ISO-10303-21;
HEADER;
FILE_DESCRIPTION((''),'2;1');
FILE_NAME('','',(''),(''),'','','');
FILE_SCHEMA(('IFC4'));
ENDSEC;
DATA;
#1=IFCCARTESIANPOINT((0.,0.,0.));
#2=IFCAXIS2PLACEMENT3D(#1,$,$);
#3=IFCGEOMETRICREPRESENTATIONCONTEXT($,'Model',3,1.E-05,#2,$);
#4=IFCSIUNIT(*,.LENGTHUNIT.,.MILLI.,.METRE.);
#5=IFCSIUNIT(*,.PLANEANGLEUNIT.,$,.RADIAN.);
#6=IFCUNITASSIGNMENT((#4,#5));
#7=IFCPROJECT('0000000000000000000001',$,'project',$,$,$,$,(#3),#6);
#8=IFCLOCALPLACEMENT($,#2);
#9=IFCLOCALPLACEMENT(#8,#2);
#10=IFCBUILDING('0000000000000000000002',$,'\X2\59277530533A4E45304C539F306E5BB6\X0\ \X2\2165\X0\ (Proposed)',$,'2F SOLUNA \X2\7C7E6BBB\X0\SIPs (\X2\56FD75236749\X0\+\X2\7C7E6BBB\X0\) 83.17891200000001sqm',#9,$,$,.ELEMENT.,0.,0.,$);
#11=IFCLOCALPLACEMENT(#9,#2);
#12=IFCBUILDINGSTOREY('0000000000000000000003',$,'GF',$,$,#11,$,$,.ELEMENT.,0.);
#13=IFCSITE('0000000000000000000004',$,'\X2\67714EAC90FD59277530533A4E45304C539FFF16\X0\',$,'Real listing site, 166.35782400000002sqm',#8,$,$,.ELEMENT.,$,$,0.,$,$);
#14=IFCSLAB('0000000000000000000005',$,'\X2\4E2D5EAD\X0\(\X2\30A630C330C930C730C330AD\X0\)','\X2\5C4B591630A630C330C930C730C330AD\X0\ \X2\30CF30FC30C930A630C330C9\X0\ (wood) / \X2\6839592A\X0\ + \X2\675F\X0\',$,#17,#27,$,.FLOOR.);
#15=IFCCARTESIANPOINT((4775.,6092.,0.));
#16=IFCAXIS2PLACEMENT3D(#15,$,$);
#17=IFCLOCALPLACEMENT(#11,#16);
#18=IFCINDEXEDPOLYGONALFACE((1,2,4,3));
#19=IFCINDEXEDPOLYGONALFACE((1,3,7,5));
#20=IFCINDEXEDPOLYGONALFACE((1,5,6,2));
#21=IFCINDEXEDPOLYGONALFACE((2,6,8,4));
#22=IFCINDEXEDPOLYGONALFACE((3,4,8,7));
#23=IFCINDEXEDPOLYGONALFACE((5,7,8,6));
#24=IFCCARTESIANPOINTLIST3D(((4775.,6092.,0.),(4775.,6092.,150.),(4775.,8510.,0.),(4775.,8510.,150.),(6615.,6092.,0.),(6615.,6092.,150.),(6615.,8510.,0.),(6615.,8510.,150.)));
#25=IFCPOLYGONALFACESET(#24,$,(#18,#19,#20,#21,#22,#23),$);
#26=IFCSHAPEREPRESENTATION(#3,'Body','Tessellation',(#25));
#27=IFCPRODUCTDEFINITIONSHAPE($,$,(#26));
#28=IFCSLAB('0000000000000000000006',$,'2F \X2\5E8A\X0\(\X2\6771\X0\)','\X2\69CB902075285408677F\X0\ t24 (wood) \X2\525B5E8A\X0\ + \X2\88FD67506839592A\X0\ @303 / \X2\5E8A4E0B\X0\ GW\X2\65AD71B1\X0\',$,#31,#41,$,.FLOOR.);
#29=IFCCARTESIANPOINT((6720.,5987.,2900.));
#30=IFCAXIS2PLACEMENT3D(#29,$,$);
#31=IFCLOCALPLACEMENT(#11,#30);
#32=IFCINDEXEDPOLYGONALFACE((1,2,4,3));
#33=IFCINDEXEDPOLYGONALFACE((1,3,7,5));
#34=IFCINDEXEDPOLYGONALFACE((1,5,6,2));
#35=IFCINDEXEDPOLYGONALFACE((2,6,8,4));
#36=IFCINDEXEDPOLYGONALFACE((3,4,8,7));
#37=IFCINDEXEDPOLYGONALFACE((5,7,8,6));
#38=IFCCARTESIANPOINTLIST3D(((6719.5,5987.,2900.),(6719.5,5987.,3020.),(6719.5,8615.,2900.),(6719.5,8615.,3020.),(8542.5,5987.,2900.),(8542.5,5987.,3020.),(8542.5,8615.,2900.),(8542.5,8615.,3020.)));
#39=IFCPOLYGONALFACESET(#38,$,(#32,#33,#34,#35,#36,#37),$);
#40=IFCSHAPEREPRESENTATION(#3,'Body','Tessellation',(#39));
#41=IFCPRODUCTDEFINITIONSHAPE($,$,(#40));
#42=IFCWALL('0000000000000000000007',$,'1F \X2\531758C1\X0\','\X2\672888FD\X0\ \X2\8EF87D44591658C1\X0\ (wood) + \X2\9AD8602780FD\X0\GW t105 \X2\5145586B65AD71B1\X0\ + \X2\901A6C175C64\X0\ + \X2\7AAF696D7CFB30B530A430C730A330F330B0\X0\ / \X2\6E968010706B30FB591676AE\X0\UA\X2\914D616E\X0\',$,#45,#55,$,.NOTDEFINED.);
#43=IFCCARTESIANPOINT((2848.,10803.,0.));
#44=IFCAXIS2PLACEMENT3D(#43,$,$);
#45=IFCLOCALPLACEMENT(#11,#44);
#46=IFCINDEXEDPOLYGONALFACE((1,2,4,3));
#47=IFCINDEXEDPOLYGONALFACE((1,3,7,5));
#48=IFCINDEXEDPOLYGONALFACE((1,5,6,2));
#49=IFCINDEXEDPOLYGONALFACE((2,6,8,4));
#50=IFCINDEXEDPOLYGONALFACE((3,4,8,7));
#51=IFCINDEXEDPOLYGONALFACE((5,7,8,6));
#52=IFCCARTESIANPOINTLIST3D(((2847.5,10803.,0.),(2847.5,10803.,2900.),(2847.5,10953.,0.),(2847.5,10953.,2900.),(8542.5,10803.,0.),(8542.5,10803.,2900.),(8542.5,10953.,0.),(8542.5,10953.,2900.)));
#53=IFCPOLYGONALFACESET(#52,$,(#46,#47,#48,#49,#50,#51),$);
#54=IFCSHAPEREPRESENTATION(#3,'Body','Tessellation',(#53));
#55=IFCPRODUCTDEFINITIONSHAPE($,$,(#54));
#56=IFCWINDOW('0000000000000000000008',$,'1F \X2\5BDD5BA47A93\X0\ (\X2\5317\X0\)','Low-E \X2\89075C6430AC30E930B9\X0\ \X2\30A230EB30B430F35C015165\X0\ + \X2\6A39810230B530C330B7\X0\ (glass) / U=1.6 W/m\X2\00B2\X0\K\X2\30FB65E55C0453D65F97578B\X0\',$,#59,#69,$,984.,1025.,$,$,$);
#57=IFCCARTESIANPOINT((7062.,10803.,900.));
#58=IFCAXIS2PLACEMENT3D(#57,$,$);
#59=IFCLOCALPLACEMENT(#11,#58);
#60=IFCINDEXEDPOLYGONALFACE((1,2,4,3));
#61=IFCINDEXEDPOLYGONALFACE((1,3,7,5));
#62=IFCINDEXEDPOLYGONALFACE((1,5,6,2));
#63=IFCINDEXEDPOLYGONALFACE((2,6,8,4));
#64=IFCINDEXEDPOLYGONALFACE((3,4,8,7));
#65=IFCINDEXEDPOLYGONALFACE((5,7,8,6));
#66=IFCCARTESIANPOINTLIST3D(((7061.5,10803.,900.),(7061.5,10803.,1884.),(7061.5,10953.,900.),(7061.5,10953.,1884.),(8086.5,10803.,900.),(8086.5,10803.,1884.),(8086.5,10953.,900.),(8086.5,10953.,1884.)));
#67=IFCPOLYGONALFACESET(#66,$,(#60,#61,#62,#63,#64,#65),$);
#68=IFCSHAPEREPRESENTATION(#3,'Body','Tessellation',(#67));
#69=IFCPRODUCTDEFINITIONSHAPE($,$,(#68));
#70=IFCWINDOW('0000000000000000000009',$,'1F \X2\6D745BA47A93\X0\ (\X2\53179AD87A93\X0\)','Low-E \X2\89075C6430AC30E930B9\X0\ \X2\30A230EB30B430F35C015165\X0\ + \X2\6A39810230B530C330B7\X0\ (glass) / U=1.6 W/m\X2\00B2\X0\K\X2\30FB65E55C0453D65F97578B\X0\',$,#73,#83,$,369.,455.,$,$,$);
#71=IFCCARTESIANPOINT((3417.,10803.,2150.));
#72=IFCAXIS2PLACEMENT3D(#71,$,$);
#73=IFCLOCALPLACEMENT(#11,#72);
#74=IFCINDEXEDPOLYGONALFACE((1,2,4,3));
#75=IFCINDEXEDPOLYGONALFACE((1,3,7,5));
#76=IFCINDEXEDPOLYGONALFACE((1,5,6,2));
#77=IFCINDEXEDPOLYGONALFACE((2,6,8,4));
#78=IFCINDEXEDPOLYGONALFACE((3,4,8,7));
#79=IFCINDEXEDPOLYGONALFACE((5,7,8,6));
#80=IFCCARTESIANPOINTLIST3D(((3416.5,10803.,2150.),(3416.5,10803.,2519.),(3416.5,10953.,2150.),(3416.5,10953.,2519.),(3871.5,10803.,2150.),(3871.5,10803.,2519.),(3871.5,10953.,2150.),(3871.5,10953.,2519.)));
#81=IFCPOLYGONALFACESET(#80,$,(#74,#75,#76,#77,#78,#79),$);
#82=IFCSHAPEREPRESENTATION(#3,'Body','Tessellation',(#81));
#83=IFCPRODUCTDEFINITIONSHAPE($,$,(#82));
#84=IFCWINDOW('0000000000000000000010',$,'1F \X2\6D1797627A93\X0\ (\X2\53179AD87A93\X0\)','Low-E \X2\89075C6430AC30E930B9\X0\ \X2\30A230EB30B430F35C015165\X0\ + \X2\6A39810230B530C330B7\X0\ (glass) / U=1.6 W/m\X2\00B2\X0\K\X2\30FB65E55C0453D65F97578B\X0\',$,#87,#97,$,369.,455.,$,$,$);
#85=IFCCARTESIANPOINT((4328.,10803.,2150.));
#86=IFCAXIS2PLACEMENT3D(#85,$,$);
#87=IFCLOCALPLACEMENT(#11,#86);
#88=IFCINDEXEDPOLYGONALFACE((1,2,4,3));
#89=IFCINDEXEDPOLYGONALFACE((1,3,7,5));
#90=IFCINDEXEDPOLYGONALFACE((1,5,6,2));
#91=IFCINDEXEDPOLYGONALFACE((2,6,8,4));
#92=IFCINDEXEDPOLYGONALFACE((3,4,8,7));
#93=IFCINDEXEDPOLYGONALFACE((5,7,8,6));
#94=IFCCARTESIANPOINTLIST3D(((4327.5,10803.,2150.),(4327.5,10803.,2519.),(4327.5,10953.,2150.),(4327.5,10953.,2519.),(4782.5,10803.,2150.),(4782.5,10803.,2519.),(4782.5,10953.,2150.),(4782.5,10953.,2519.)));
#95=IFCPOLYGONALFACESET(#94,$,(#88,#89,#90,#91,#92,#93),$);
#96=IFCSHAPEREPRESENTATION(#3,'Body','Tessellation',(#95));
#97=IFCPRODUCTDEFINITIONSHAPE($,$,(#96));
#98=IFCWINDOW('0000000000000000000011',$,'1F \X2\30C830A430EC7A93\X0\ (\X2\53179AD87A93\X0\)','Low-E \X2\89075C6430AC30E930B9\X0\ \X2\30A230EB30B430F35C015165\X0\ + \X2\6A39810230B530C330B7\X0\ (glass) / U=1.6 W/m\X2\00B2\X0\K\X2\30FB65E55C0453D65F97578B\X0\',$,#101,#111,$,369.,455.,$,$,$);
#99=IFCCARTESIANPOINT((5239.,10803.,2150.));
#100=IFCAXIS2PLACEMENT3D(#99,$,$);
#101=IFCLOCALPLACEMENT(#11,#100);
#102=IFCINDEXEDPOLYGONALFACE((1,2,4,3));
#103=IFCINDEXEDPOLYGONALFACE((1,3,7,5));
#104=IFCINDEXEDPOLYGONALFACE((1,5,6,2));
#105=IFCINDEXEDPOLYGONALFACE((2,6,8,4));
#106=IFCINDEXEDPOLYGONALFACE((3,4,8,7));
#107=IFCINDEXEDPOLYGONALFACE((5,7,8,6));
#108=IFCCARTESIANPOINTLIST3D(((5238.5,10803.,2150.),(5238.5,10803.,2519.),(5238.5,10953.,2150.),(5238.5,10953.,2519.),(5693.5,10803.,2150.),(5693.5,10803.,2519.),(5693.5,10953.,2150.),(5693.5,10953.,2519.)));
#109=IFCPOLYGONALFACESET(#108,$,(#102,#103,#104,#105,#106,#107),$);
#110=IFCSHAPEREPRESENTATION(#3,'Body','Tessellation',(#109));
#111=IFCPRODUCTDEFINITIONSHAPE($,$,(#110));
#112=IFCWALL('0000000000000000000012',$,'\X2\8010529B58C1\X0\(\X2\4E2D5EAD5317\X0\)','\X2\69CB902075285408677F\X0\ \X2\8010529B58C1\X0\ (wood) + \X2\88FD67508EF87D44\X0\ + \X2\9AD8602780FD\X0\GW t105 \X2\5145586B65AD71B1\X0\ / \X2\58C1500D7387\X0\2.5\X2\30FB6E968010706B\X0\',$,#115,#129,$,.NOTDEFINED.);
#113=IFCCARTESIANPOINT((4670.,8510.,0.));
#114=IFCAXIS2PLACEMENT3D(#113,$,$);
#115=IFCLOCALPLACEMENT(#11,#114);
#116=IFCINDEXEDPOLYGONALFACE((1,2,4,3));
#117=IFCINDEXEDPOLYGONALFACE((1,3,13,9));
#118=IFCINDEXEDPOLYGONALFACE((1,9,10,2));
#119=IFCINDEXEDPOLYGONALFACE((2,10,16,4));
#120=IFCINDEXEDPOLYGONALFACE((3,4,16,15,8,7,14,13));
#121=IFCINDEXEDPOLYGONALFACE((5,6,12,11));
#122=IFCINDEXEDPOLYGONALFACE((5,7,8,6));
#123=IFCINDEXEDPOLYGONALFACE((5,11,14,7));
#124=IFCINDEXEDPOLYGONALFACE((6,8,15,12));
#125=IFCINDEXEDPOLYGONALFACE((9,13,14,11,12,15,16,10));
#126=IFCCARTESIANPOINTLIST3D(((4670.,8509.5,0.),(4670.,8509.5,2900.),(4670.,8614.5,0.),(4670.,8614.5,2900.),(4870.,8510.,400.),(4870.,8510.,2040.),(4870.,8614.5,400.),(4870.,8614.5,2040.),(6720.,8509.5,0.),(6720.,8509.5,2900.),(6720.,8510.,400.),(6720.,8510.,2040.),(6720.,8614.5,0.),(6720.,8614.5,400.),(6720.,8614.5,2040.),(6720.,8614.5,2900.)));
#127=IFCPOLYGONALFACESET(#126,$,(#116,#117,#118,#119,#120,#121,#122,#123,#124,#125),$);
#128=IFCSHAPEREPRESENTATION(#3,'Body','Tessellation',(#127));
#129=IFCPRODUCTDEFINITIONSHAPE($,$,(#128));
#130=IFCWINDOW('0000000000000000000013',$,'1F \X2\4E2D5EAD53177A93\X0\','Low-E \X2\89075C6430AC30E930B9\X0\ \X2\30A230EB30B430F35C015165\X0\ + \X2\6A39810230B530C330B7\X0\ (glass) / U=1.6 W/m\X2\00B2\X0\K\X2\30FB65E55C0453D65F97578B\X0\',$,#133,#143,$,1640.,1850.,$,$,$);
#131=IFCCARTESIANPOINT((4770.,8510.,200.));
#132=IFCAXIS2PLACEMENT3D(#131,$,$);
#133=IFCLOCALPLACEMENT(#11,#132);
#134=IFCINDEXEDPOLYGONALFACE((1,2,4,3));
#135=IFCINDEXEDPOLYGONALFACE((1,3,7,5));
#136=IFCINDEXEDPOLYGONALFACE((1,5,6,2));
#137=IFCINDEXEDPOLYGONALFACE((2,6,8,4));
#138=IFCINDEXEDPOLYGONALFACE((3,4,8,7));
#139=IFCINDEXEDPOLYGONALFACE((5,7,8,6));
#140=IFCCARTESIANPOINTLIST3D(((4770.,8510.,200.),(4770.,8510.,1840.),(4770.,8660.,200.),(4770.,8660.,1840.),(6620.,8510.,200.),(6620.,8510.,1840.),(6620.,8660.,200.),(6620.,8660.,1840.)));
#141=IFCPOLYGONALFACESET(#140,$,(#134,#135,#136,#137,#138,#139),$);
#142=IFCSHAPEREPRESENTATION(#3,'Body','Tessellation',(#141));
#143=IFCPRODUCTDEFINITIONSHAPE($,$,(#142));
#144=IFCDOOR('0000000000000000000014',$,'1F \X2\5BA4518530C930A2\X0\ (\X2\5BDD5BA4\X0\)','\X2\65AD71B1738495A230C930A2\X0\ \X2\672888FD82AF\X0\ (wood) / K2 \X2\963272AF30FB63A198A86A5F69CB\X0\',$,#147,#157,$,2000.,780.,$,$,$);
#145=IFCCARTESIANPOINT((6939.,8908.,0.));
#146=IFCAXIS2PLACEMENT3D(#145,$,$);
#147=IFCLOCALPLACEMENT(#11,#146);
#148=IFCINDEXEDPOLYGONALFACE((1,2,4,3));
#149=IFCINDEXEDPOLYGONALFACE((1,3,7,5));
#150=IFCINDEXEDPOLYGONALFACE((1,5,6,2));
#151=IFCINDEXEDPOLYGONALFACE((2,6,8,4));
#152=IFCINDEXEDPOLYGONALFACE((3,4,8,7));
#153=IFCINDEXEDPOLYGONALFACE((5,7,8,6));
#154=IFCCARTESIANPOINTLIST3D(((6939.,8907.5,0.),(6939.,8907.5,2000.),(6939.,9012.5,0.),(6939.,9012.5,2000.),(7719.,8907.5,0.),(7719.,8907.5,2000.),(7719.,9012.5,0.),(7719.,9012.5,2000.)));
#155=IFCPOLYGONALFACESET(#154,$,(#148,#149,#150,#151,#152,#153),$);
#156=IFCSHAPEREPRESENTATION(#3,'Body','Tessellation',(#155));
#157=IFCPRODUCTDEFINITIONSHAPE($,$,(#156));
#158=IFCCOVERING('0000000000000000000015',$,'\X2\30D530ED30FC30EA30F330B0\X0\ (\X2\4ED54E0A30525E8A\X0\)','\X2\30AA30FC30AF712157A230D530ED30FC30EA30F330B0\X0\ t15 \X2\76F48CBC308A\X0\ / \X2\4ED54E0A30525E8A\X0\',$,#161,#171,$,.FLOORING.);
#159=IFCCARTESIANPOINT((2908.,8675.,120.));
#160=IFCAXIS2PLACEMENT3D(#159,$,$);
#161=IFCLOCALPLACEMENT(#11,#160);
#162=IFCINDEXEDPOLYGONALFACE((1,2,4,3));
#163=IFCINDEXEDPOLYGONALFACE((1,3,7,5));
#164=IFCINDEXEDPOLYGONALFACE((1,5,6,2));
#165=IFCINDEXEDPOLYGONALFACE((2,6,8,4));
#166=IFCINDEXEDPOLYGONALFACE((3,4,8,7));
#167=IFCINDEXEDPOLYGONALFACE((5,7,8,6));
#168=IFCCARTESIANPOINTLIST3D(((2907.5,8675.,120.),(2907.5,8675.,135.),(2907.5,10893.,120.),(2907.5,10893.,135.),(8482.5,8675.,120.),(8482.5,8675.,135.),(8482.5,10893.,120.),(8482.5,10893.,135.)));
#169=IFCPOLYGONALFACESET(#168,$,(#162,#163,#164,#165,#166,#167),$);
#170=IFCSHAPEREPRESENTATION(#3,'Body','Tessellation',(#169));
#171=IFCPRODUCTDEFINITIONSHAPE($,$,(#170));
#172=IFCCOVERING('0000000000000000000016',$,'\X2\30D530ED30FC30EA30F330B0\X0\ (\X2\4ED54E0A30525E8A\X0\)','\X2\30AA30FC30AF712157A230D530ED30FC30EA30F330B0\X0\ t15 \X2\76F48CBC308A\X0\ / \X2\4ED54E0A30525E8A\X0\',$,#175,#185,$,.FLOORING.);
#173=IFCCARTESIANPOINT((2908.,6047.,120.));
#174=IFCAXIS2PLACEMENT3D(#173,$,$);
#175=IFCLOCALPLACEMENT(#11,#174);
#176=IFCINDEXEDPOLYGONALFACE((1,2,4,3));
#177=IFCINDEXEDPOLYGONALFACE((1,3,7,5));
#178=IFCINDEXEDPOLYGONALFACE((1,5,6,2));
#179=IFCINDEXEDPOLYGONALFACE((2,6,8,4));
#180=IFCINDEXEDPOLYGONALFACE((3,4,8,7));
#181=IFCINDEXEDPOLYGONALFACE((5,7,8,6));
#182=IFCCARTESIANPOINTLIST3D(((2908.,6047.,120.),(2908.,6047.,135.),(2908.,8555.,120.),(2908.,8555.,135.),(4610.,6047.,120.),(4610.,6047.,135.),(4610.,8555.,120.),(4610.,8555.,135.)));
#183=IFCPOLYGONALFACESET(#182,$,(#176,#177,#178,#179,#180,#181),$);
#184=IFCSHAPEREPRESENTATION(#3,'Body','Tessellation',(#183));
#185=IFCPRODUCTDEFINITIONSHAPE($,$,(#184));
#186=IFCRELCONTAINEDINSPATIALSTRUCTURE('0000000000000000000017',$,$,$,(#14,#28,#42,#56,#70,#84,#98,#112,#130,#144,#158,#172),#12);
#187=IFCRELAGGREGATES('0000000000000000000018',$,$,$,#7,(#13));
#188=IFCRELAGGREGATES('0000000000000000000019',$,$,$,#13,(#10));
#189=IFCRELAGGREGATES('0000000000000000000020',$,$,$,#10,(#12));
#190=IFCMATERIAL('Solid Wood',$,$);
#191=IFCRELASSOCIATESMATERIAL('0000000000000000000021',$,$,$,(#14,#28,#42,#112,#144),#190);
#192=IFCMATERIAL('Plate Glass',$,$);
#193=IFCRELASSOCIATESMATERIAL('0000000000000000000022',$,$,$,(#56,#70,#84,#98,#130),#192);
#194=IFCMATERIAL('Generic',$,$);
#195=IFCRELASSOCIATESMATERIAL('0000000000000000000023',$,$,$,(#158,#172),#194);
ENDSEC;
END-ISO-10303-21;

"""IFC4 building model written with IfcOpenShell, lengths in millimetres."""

from ifc_helpers import new_model, si_unit, frame, frame_2d, origin, place, context, project, spatial, rectangle, extrude, material, element, fill, save


model = new_model("IFC4")

# Units and contexts
model_context = context("Model", 3, precision=1e-05, world=origin())
ifc_project = project(units=[si_unit("LENGTHUNIT", "METRE", prefix="MILLI"), si_unit("PLANEANGLEUNIT", "RADIAN")], contexts=[model_context])

# Site, building, storey
site_placement = place(None, origin())
site = spatial("IfcSite", under=ifc_project, at=site_placement, Name="東京都大田区久が原６", ObjectType="Real listing site, 166.35782400000002sqm", CompositionType="ELEMENT", RefElevation=0.0)
building_placement = place(site_placement, origin())
building = spatial("IfcBuilding", under=site, at=building_placement, Name="大田区久が原の家 Ⅵ (Proposed)", ObjectType="2F SOLUNA 籾殻SIPs (国産杉+籾殻) 83.17891200000001sqm", CompositionType="ELEMENT", ElevationOfRefHeight=0.0, ElevationOfTerrain=0.0)
storey_placement = place(building_placement, origin())
storey = spatial("IfcBuildingStorey", under=building, at=storey_placement, Name="GF", CompositionType="ELEMENT", Elevation=0.0)

# Slabs
ifc_material_1 = material(Name="Solid Wood")
slab_1_placement = place(storey_placement, frame((4775.0, 6092.0, 0.0)))
element("IfcSlab", 1, at=slab_1_placement, inside=storey, material=ifc_material_1, Name="中庭(ウッドデッキ)", Description="屋外ウッドデッキ ハードウッド (wood) / 根太 + 束", PredefinedType="FLOOR", context=model_context, shape_type="SweptSolid", body=[
    extrude(rectangle(XDim=1840.0, YDim=2418.0, at=frame_2d((920.0, 1209.0))), frame((4775.0, 6092.0, 0.0)), (0.0, 0.0, 1.0), 150.0),
])
slab_2_placement = place(storey_placement, frame((6720.0, 5987.0, 2900.0)))
element("IfcSlab", 2, at=slab_2_placement, inside=storey, material=ifc_material_1, Name="2F 床(東)", Description="構造用合板 t24 (wood) 剛床 + 製材根太 @303 / 床下 GW断熱", PredefinedType="FLOOR", context=model_context, shape_type="SweptSolid", body=[
    extrude(rectangle(XDim=1823.0, YDim=2628.0, at=frame_2d((911.0, 1314.0))), frame((6720.0, 5987.0, 2900.0)), (0.0, 0.0, 1.0), 120.0),
])

# Wall, openings, windows
wall_1_placement = place(storey_placement, frame((2848.0, 10803.0, 0.0)))
wall_1 = element("IfcWall", 3, at=wall_1_placement, inside=storey, material=ifc_material_1, Name="1F 北壁", Description="木製 軸組外壁 (wood) + 高性能GW t105 充填断熱 + 通気層 + 窯業系サイディング / 準耐火・外皮UA配慮", PredefinedType="NOTDEFINED", context=model_context, shape_type="SweptSolid", body=[
    extrude(rectangle(XDim=5695.0, YDim=150.0, at=frame_2d((2847.0, 75.0))), frame((2848.0, 10803.0, 0.0)), (0.0, 0.0, 1.0), 2900.0),
])
opening_1_placement = place(storey_placement, frame((7062.0, 10803.0, 900.0)))
opening_1 = element("IfcOpeningElement", 4, at=opening_1_placement, cuts=wall_1, PredefinedType="NOTDEFINED", context=model_context, shape_type="SweptSolid", body=[
    extrude(rectangle(XDim=1025.0, YDim=150.0, at=frame_2d((512.0, 75.0))), frame((7062.0, 10803.0, 900.0)), (0.0, 0.0, 1.0), 984.0),
])
opening_2_placement = place(storey_placement, frame((3417.0, 10803.0, 2150.0)))
opening_2 = element("IfcOpeningElement", 5, at=opening_2_placement, cuts=wall_1, PredefinedType="NOTDEFINED", context=model_context, shape_type="SweptSolid", body=[
    extrude(rectangle(XDim=455.0, YDim=150.0, at=frame_2d((227.0, 75.0))), frame((3417.0, 10803.0, 2150.0)), (0.0, 0.0, 1.0), 369.0),
])
opening_3_placement = place(storey_placement, frame((4328.0, 10803.0, 2150.0)))
opening_3 = element("IfcOpeningElement", 6, at=opening_3_placement, cuts=wall_1, PredefinedType="NOTDEFINED", context=model_context, shape_type="SweptSolid", body=[
    extrude(rectangle(XDim=455.0, YDim=150.0, at=frame_2d((227.0, 75.0))), frame((4328.0, 10803.0, 2150.0)), (0.0, 0.0, 1.0), 369.0),
])
opening_4_placement = place(storey_placement, frame((5239.0, 10803.0, 2150.0)))
opening_4 = element("IfcOpeningElement", 7, at=opening_4_placement, cuts=wall_1, PredefinedType="NOTDEFINED", context=model_context, shape_type="SweptSolid", body=[
    extrude(rectangle(XDim=455.0, YDim=150.0, at=frame_2d((227.0, 75.0))), frame((5239.0, 10803.0, 2150.0)), (0.0, 0.0, 1.0), 369.0),
])
ifc_material_2 = material(Name="Plate Glass")
window_1_placement = place(storey_placement, frame((7062.0, 10803.0, 900.0)))
window_1 = element("IfcWindow", 8, at=window_1_placement, inside=storey, material=ifc_material_2, Name="1F 寝室窓 (北)", Description="Low-E 複層ガラス アルゴン封入 + 樹脂サッシ (glass) / U=1.6 W/m²K・日射取得型", OverallHeight=984.0, OverallWidth=1025.0, context=model_context, shape_type="SweptSolid", body=[
    extrude(rectangle(XDim=1025.0, YDim=150.0, at=frame_2d((512.0, 75.0))), frame((7062.0, 10803.0, 900.0)), (0.0, 0.0, 1.0), 984.0),
])
fill(opening_1, window_1)
window_2_placement = place(storey_placement, frame((3417.0, 10803.0, 2150.0)))
window_2 = element("IfcWindow", 9, at=window_2_placement, inside=storey, material=ifc_material_2, Name="1F 浴室窓 (北高窓)", Description="Low-E 複層ガラス アルゴン封入 + 樹脂サッシ (glass) / U=1.6 W/m²K・日射取得型", OverallHeight=369.0, OverallWidth=455.0, context=model_context, shape_type="SweptSolid", body=[
    extrude(rectangle(XDim=455.0, YDim=150.0, at=frame_2d((227.0, 75.0))), frame((3417.0, 10803.0, 2150.0)), (0.0, 0.0, 1.0), 369.0),
])
fill(opening_2, window_2)
window_3_placement = place(storey_placement, frame((4328.0, 10803.0, 2150.0)))
window_3 = element("IfcWindow", 10, at=window_3_placement, inside=storey, material=ifc_material_2, Name="1F 洗面窓 (北高窓)", Description="Low-E 複層ガラス アルゴン封入 + 樹脂サッシ (glass) / U=1.6 W/m²K・日射取得型", OverallHeight=369.0, OverallWidth=455.0, context=model_context, shape_type="SweptSolid", body=[
    extrude(rectangle(XDim=455.0, YDim=150.0, at=frame_2d((227.0, 75.0))), frame((4328.0, 10803.0, 2150.0)), (0.0, 0.0, 1.0), 369.0),
])
fill(opening_3, window_3)
window_4_placement = place(storey_placement, frame((5239.0, 10803.0, 2150.0)))
window_4 = element("IfcWindow", 11, at=window_4_placement, inside=storey, material=ifc_material_2, Name="1F トイレ窓 (北高窓)", Description="Low-E 複層ガラス アルゴン封入 + 樹脂サッシ (glass) / U=1.6 W/m²K・日射取得型", OverallHeight=369.0, OverallWidth=455.0, context=model_context, shape_type="SweptSolid", body=[
    extrude(rectangle(XDim=455.0, YDim=150.0, at=frame_2d((227.0, 75.0))), frame((5239.0, 10803.0, 2150.0)), (0.0, 0.0, 1.0), 369.0),
])
fill(opening_4, window_4)

# Wall, opening, window
wall_2_placement = place(storey_placement, frame((4670.0, 8510.0, 0.0)))
wall_2 = element("IfcWall", 12, at=wall_2_placement, inside=storey, material=ifc_material_1, Name="耐力壁(中庭北)", Description="構造用合板 耐力壁 (wood) + 製材軸組 + 高性能GW t105 充填断熱 / 壁倍率2.5・準耐火", PredefinedType="NOTDEFINED", context=model_context, shape_type="SweptSolid", body=[
    extrude(rectangle(XDim=2050.0, YDim=105.0, at=frame_2d((1025.0, 52.0))), frame((4670.0, 8510.0, 0.0)), (0.0, 0.0, 1.0), 2900.0),
])
opening_5_placement = place(storey_placement, frame((4770.0, 8510.0, 200.0)))
opening_5 = element("IfcOpeningElement", 13, at=opening_5_placement, cuts=wall_2, PredefinedType="NOTDEFINED", context=model_context, shape_type="SweptSolid", body=[
    extrude(rectangle(XDim=1850.0, YDim=150.0, at=frame_2d((925.0, 75.0))), frame((4770.0, 8510.0, 200.0)), (0.0, 0.0, 1.0), 1640.0),
])
window_5_placement = place(storey_placement, frame((4770.0, 8510.0, 200.0)))
window_5 = element("IfcWindow", 14, at=window_5_placement, inside=storey, material=ifc_material_2, Name="1F 中庭北窓", Description="Low-E 複層ガラス アルゴン封入 + 樹脂サッシ (glass) / U=1.6 W/m²K・日射取得型", OverallHeight=1640.0, OverallWidth=1850.0, context=model_context, shape_type="SweptSolid", body=[
    extrude(rectangle(XDim=1850.0, YDim=150.0, at=frame_2d((925.0, 75.0))), frame((4770.0, 8510.0, 200.0)), (0.0, 0.0, 1.0), 1640.0),
])
fill(opening_5, window_5)

# Door
door_1_placement = place(storey_placement, frame((6939.0, 8908.0, 0.0)))
element("IfcDoor", 15, at=door_1_placement, inside=storey, material=ifc_material_1, Name="1F 室内ドア (寝室)", Description="断熱玄関ドア 木製芯 (wood) / K2 防犯・採風機構", OverallHeight=2000.0, OverallWidth=780.0, context=model_context, shape_type="SweptSolid", body=[
    extrude(rectangle(XDim=780.0, YDim=105.0, at=frame_2d((390.0, 52.0))), frame((6939.0, 8908.0, 0.0)), (0.0, 0.0, 1.0), 2000.0),
])

# Coverings
ifc_material_3 = material(Name="Generic")
covering_1_placement = place(storey_placement, frame((2908.0, 8675.0, 120.0)))
element("IfcCovering", 16, at=covering_1_placement, inside=storey, material=ifc_material_3, Name="フローリング (仕上げ床)", Description="オーク無垢フローリング t15 直貼り / 仕上げ床", PredefinedType="FLOORING", context=model_context, shape_type="SweptSolid", body=[
    extrude(rectangle(XDim=5575.0, YDim=2218.0, at=frame_2d((2787.0, 1109.0))), frame((2908.0, 8675.0, 120.0)), (0.0, 0.0, 1.0), 15.0),
])
covering_2_placement = place(storey_placement, frame((2908.0, 6047.0, 120.0)))
element("IfcCovering", 17, at=covering_2_placement, inside=storey, material=ifc_material_3, Name="フローリング (仕上げ床)", Description="オーク無垢フローリング t15 直貼り / 仕上げ床", PredefinedType="FLOORING", context=model_context, shape_type="SweptSolid", body=[
    extrude(rectangle(XDim=1702.0, YDim=2508.0, at=frame_2d((851.0, 1254.0))), frame((2908.0, 6047.0, 120.0)), (0.0, 0.0, 1.0), 15.0),
])

save(model, "model.ifc")
